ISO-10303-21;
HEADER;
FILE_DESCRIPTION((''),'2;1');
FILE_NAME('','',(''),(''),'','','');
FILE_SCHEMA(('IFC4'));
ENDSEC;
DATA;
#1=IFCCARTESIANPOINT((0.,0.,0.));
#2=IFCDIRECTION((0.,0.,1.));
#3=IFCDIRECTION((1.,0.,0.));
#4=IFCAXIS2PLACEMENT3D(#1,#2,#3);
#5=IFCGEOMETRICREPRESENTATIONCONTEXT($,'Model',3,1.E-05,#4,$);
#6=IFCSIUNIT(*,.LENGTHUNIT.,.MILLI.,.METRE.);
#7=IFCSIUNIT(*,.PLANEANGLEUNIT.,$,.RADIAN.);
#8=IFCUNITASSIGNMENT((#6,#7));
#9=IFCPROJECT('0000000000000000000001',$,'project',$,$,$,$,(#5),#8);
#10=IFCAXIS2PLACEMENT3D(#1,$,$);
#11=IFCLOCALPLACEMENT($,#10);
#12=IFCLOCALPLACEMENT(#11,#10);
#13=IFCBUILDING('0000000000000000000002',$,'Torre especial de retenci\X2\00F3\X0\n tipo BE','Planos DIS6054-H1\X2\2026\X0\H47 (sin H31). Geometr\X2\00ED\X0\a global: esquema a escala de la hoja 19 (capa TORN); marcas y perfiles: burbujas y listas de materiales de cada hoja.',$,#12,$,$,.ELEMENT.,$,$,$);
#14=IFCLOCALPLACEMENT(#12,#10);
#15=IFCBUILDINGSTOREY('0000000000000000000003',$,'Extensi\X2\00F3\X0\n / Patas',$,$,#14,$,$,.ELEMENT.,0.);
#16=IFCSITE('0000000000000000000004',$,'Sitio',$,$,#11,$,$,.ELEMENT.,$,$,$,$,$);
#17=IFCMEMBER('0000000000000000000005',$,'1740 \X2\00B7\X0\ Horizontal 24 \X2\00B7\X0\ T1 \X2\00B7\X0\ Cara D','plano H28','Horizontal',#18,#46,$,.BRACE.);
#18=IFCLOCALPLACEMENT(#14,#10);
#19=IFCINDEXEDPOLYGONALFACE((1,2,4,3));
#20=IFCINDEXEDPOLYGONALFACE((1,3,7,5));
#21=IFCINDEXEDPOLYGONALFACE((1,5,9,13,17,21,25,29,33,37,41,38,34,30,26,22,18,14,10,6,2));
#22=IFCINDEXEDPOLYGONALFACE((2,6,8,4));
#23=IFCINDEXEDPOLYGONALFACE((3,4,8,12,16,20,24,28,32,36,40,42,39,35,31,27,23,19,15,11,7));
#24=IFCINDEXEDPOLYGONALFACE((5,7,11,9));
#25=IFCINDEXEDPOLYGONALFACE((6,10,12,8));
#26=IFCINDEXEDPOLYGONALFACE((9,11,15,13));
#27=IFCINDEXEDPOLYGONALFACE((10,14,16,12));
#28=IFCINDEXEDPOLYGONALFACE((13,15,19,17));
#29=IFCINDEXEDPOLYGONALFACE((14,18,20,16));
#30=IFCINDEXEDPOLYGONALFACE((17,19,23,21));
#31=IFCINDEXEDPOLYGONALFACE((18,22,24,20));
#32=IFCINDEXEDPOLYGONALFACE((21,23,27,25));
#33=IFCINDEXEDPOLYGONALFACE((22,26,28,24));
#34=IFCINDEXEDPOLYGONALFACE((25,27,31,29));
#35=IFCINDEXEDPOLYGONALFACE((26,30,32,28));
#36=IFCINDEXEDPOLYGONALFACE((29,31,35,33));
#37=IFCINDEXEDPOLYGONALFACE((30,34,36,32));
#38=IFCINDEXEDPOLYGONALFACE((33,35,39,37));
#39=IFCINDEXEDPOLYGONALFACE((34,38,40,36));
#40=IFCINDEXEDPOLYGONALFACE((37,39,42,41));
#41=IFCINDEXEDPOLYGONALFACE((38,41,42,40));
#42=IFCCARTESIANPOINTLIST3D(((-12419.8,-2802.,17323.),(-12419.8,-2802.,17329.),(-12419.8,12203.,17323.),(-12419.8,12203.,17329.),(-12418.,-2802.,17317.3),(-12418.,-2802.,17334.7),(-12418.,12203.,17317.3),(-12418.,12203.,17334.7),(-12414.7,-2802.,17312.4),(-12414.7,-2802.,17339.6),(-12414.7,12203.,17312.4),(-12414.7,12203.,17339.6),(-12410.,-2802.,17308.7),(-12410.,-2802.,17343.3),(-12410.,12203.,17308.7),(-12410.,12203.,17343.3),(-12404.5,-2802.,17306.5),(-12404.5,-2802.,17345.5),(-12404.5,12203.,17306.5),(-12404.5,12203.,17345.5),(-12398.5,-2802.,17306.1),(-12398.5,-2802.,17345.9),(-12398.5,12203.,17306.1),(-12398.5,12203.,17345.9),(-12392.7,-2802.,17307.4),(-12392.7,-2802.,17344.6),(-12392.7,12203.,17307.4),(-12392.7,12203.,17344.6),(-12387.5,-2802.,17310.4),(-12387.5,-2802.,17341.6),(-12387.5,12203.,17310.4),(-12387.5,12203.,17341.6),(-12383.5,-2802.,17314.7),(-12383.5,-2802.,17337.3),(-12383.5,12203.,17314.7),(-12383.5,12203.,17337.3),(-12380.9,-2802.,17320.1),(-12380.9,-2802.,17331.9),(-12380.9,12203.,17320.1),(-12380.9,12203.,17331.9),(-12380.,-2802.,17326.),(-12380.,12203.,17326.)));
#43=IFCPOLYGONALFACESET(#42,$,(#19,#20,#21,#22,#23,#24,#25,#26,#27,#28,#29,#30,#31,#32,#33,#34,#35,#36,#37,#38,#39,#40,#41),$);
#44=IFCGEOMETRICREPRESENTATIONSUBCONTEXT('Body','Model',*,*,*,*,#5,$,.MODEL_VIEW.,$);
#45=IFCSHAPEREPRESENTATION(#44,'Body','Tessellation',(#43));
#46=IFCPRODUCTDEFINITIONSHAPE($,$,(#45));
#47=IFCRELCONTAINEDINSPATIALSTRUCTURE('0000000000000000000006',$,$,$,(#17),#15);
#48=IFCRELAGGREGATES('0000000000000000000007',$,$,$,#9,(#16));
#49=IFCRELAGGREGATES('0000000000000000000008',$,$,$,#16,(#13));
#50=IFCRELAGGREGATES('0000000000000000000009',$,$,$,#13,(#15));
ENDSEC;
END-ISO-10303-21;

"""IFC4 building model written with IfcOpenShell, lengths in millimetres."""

from ifc_helpers import new_model, si_unit, frame, origin, origin_with_axes, place, context, subcontext, project, spatial, circle, extrude, element, save


model = new_model("IFC4")

# Units and contexts
model_context = context("Model", 3, precision=1e-05, world=origin_with_axes())
body_context = subcontext(model_context, "Body", "Model", "MODEL_VIEW")
ifc_project = project(units=[si_unit("LENGTHUNIT", "METRE", prefix="MILLI"), si_unit("PLANEANGLEUNIT", "RADIAN")], contexts=[model_context])

# Site, building, storey
site_placement = place(None, origin())
site = spatial("IfcSite", under=ifc_project, at=site_placement, Name="Sitio", CompositionType="ELEMENT")
building_placement = place(site_placement, origin())
building = spatial("IfcBuilding", under=site, at=building_placement, Name="Torre especial de retención tipo BE", Description="Planos DIS6054-H1…H47 (sin H31). Geometría global: esquema a escala de la hoja 19 (capa TORN); marcas y perfiles: burbujas y listas de materiales de cada hoja.", CompositionType="ELEMENT")
storey_placement = place(building_placement, origin())
storey = spatial("IfcBuildingStorey", under=building, at=storey_placement, Name="Extensión / Patas", CompositionType="ELEMENT", Elevation=0.0)

# Member
member_1_placement = place(storey_placement, frame((-12400.0, 12203.0, 17326.0), z_axis=(0.0, -1.0, 0.0), x_axis=(1.0, 0.0, 0.0)))
element("IfcMember", 1, at=member_1_placement, inside=storey, Name="1740 · Horizontal 24 · T1 · Cara D", Description="plano H28", ObjectType="Horizontal", PredefinedType="BRACE", context=body_context, shape_type="SweptSolid", body=[
    extrude(circle(Radius=20.0), None, (0.0, 0.0, 1.0), 15005.0),
])

save(model, "model.ifc")
